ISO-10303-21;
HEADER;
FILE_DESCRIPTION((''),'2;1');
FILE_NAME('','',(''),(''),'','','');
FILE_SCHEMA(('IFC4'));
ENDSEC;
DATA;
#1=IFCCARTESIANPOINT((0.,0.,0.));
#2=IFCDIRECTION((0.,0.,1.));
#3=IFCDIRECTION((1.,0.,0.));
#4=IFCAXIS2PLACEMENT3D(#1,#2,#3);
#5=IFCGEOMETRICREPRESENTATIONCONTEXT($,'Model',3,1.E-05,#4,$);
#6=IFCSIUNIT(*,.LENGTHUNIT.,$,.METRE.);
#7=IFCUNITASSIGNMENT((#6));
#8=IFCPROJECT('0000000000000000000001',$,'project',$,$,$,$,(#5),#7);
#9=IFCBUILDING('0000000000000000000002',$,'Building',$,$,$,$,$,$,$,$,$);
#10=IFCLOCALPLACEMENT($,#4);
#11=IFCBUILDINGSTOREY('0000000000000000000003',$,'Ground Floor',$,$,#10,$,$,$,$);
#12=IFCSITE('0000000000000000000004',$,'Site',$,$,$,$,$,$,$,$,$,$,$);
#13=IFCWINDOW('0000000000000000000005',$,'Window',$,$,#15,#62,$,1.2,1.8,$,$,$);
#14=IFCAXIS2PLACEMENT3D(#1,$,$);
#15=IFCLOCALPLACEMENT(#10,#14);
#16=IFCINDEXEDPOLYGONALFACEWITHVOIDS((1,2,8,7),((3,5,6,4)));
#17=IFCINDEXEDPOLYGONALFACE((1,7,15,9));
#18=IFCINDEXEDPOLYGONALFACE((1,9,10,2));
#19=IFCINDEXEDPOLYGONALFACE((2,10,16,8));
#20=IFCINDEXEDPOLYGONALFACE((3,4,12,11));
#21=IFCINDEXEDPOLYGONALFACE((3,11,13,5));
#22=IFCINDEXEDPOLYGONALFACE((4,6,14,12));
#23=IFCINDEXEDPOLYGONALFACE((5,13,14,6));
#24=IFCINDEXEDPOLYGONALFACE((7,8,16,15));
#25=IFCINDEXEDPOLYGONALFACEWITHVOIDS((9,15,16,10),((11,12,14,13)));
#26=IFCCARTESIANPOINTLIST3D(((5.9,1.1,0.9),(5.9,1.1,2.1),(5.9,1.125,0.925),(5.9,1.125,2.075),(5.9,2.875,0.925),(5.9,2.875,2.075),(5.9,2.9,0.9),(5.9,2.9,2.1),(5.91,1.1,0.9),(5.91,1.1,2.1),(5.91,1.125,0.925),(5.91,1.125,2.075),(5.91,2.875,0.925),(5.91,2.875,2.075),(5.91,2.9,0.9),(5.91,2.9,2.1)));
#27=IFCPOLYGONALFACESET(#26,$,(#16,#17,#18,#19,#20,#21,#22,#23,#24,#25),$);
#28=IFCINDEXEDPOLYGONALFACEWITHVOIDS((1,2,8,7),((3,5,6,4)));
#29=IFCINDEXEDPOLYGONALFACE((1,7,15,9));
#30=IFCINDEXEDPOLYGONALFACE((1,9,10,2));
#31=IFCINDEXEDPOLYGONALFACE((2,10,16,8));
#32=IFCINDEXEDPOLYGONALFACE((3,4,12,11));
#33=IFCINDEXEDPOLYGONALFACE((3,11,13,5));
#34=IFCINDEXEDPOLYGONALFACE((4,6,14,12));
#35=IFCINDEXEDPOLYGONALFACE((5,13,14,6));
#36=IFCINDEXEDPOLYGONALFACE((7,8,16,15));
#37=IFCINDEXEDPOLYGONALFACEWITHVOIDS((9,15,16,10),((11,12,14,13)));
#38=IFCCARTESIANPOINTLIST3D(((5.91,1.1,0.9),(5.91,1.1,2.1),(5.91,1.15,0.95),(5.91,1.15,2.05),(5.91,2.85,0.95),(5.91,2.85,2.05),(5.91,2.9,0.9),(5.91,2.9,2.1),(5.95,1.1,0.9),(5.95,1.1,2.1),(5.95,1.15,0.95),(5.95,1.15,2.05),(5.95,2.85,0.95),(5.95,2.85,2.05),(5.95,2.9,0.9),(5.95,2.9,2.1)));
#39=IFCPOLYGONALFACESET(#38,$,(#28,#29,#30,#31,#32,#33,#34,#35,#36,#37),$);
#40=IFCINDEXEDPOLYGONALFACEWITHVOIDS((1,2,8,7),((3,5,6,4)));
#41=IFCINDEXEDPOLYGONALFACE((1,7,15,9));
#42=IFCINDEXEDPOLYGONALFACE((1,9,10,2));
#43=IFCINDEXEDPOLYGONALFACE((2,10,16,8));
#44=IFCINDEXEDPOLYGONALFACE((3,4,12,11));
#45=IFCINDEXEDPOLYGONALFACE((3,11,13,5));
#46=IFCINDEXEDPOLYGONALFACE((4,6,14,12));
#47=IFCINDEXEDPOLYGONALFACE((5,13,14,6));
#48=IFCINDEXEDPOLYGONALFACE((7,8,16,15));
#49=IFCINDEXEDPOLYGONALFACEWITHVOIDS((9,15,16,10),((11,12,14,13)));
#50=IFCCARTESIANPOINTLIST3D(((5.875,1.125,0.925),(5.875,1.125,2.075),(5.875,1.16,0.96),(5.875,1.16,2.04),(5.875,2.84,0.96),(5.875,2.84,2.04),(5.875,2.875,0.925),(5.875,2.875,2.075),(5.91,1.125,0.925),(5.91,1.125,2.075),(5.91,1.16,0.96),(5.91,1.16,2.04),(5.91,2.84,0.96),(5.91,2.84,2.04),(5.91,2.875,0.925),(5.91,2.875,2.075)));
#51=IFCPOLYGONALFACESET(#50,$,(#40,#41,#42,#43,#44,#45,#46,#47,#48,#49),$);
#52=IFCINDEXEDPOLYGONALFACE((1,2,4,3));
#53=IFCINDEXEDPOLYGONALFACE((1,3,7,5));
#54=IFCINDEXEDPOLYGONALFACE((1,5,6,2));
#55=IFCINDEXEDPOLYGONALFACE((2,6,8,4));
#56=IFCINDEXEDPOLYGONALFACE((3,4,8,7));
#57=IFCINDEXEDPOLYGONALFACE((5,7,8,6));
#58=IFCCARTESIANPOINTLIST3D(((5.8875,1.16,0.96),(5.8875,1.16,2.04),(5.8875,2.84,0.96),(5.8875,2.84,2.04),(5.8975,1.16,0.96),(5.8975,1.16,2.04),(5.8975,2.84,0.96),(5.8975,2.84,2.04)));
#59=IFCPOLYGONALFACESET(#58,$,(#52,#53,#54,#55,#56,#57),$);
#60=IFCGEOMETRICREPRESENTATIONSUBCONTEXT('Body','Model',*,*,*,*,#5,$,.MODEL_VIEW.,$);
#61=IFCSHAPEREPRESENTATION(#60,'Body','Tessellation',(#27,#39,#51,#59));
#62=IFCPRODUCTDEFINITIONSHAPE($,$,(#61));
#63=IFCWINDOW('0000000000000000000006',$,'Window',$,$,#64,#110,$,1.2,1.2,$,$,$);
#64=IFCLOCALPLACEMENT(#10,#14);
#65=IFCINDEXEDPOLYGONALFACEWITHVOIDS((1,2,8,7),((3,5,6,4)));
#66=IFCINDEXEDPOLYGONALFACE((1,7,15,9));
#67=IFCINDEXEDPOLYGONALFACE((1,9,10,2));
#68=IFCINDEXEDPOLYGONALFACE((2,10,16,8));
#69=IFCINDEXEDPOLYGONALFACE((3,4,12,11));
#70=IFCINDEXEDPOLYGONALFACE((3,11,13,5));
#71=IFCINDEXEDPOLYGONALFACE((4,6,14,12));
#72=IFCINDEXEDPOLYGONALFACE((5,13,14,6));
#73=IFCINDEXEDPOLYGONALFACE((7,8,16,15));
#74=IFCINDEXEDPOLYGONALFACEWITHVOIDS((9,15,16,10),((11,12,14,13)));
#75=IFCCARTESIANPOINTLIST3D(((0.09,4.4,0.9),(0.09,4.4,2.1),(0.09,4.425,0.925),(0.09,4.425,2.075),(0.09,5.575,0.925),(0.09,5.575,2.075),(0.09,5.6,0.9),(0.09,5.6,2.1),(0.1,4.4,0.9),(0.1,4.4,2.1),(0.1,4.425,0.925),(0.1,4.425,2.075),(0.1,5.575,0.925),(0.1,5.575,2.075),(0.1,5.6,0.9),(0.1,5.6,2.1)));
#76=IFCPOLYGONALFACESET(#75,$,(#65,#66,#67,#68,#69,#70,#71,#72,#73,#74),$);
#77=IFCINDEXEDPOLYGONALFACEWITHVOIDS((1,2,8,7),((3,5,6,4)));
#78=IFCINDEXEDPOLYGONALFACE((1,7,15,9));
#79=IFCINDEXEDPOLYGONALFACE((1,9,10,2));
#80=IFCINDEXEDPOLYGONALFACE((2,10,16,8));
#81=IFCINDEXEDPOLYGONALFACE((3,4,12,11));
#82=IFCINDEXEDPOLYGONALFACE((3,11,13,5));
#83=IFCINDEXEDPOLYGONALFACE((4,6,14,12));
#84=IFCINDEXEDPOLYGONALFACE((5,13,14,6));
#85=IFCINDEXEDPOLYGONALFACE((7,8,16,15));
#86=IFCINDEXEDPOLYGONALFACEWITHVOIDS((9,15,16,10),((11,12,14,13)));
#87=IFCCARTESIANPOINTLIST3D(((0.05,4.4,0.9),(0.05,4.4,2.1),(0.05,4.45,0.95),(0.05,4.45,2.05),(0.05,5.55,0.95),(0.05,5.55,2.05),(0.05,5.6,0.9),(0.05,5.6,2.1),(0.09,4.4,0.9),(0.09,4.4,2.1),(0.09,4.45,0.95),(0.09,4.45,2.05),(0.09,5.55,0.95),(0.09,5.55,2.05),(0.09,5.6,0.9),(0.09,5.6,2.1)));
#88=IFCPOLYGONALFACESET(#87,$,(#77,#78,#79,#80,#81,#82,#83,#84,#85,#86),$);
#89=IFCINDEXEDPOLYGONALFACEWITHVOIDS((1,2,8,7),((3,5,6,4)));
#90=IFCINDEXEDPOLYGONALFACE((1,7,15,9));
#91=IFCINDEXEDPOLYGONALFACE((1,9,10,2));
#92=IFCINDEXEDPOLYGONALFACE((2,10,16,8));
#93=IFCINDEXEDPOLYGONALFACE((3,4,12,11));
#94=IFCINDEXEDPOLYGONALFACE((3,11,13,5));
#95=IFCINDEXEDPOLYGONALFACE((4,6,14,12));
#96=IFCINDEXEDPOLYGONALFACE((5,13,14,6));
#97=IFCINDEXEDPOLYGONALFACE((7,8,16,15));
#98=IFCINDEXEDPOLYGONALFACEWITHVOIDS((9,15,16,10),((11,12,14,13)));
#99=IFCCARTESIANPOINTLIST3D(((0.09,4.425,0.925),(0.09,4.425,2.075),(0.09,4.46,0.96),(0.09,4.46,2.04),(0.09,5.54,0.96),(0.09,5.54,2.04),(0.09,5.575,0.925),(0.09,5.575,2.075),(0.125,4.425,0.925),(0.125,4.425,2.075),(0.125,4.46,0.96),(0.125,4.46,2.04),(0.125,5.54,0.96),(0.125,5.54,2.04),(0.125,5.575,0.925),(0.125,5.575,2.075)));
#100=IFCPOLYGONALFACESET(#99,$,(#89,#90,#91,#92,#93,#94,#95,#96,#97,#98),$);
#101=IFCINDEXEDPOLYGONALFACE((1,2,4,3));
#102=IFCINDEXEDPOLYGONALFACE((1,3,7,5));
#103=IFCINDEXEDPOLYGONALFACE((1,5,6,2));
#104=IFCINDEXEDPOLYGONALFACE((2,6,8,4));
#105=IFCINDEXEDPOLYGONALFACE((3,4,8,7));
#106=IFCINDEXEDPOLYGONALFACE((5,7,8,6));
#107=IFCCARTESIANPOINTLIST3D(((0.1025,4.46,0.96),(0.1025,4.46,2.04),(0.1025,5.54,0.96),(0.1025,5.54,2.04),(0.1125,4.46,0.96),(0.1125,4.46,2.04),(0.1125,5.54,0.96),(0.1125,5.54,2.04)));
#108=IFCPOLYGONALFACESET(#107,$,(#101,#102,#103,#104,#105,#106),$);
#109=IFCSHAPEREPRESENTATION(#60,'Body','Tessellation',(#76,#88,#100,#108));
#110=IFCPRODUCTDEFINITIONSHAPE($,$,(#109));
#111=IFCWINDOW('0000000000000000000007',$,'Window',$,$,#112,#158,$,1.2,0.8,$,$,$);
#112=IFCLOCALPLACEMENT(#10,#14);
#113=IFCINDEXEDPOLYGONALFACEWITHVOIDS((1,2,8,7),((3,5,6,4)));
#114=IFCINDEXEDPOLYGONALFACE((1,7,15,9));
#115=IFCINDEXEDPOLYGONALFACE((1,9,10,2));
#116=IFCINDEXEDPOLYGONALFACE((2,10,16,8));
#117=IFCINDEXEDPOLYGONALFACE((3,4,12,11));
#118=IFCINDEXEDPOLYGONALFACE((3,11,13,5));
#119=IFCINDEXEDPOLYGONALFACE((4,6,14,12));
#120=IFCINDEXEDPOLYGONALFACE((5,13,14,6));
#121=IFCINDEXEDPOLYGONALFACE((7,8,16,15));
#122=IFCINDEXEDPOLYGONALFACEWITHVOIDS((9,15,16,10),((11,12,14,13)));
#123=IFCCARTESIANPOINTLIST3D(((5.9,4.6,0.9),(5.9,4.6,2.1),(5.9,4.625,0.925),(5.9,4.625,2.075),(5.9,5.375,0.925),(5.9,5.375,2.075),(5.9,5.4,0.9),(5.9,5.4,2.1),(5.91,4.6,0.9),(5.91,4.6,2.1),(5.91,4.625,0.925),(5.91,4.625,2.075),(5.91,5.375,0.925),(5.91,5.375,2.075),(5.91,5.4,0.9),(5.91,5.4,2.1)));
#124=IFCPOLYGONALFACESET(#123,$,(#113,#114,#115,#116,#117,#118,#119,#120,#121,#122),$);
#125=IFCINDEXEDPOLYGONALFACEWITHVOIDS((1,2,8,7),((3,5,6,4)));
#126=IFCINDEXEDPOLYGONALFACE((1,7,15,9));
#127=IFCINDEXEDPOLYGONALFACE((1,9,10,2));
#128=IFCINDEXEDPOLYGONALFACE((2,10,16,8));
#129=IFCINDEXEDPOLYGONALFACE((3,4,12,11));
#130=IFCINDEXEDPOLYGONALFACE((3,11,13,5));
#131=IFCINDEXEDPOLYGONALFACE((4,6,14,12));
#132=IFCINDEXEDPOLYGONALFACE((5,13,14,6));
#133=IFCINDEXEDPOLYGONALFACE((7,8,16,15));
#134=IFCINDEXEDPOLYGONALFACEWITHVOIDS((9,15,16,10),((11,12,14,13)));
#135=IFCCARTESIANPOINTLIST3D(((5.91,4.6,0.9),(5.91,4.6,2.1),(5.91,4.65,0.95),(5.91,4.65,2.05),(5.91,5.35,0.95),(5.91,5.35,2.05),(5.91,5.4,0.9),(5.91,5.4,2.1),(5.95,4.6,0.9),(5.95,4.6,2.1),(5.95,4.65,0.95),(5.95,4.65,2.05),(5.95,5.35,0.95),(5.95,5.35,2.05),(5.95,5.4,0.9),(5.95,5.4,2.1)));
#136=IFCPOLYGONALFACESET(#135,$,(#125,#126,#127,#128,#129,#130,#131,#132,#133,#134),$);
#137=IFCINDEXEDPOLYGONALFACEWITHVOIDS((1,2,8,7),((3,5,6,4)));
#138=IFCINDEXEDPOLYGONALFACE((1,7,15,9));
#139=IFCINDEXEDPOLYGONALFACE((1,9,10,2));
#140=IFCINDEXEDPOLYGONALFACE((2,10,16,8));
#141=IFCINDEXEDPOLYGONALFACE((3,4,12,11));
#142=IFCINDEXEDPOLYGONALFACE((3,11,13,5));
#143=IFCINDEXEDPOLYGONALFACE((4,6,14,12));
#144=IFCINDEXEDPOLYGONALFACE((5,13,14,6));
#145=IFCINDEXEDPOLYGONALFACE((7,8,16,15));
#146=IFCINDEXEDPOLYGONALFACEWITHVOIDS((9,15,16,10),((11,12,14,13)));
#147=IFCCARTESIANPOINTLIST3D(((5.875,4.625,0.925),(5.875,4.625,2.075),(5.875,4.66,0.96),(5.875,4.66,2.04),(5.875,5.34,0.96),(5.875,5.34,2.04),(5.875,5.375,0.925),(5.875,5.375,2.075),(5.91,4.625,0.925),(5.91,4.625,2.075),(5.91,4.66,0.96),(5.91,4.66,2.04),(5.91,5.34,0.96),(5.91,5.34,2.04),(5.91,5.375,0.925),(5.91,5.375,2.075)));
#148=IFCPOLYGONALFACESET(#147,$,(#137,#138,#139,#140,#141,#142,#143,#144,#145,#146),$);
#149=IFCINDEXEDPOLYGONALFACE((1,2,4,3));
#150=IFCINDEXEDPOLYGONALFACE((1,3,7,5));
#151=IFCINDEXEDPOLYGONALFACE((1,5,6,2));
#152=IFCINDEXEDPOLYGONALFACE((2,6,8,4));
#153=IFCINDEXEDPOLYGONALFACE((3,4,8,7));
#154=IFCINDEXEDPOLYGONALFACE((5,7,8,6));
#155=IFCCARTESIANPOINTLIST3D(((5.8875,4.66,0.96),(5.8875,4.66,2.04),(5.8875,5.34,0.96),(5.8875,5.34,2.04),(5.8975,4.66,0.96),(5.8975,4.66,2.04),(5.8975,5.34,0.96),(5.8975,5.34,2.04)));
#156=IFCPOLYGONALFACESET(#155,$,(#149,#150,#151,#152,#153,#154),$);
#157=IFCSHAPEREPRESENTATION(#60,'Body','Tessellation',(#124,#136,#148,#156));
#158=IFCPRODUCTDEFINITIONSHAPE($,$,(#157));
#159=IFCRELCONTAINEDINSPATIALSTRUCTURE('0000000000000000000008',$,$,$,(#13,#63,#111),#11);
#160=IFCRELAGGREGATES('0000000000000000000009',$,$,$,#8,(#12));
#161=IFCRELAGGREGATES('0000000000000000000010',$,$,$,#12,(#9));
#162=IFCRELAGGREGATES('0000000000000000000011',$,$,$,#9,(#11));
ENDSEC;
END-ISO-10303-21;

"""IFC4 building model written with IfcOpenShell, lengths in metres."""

from ifc_helpers import new_model, si_unit, frame, origin_with_axes, place, context, subcontext, project, spatial, line, indexed_curve, outline, extrude, element, save


model = new_model("IFC4")

# Units and contexts
model_context = context("Model", 3, precision=1e-05, world=origin_with_axes())
body_context = subcontext(model_context, "Body", "Model", "MODEL_VIEW")
ifc_project = project(units=[si_unit("LENGTHUNIT", "METRE")], contexts=[model_context])

# Site, building, storey
site = spatial("IfcSite", under=ifc_project, Name="Site")
building = spatial("IfcBuilding", under=site, Name="Building")
storey_placement = place(None, origin_with_axes())
storey = spatial("IfcBuildingStorey", under=building, at=storey_placement, Name="Ground Floor")

# Windows
for number, where, z_axis, x_axis, name in (
    (1, (6.0, 1.1, 0.9), (0.0, 0.0, 1.0), (0.0, 1.0, 0.0), "Window"),
):
    element("IfcWindow", number, at=place(storey_placement, frame(where, z_axis=z_axis, x_axis=x_axis)), inside=storey, Name=name, OverallHeight=1.2, OverallWidth=1.8, context=body_context, shape_type="SweptSolid", body=[
        extrude(outline(indexed_curve([(0.0, 0.0), (1.8, 0.0), (1.8, 1.2), (0.0, 1.2)], segments=[line(1, 2, 3, 4, 1)]), holes=[indexed_curve([(0.025, 0.025), (1.775, 0.025), (1.775, 1.175), (0.025, 1.175)], segments=[line(1, 2, 3, 4, 1)])]), frame((0.0, 0.09, 0.0), z_axis=(0.0, -1.0, 0.0), x_axis=(1.0, 0.0, 0.0)), (0.0, 0.0, -1.0), 0.01),
        extrude(outline(indexed_curve([(0.0, 0.0), (1.8, 0.0), (1.8, 1.2), (0.0, 1.2)], segments=[line(1, 2, 3, 4, 1)]), holes=[indexed_curve([(0.05, 0.05), (1.75, 0.05), (1.75, 1.15), (0.05, 1.15)], segments=[line(1, 2, 3, 4, 1)])]), frame((0.0, 0.05, 0.0), z_axis=(0.0, -1.0, 0.0), x_axis=(1.0, 0.0, 0.0)), (0.0, 0.0, -1.0), 0.04),
        extrude(outline(indexed_curve([(0.0, 0.0), (1.75, 0.0), (1.75, 1.15), (0.0, 1.15)], segments=[line(1, 2, 3, 4, 1)]), holes=[indexed_curve([(0.035, 0.035), (1.715, 0.035), (1.715, 1.115), (0.035, 1.115)], segments=[line(1, 2, 3, 4, 1)])]), frame((0.025, 0.09, 0.025), z_axis=(0.0, -1.0, 0.0), x_axis=(1.0, 0.0, 0.0)), (0.0, 0.0, -1.0), 0.035),
        extrude(outline(indexed_curve([(0.035, 0.035), (1.715, 0.035), (1.715, 1.115), (0.035, 1.115)], segments=[line(1, 2, 3, 4, 1)])), frame((0.025, 0.1025, 0.025), z_axis=(0.0, -1.0, 0.0), x_axis=(1.0, 0.0, 0.0)), (0.0, 0.0, -1.0), 0.01),
    ])
window_1_placement = place(storey_placement, frame((0.0, 5.6, 0.9), z_axis=(0.0, 0.0, 1.0), x_axis=(0.0, -1.0, 0.0)))
element("IfcWindow", 2, at=window_1_placement, inside=storey, Name="Window", OverallHeight=1.2, OverallWidth=1.2, context=body_context, shape_type="SweptSolid", body=[
    extrude(outline(indexed_curve([(0.0, 0.0), (1.2, 0.0), (1.2, 1.2), (0.0, 1.2)], segments=[line(1, 2, 3, 4, 1)]), holes=[indexed_curve([(0.025, 0.025), (1.175, 0.025), (1.175, 1.175), (0.025, 1.175)], segments=[line(1, 2, 3, 4, 1)])]), frame((0.0, 0.09, 0.0), z_axis=(0.0, -1.0, 0.0), x_axis=(1.0, 0.0, 0.0)), (0.0, 0.0, -1.0), 0.01),
    extrude(outline(indexed_curve([(0.0, 0.0), (1.2, 0.0), (1.2, 1.2), (0.0, 1.2)], segments=[line(1, 2, 3, 4, 1)]), holes=[indexed_curve([(0.05, 0.05), (1.15, 0.05), (1.15, 1.15), (0.05, 1.15)], segments=[line(1, 2, 3, 4, 1)])]), frame((0.0, 0.05, 0.0), z_axis=(0.0, -1.0, 0.0), x_axis=(1.0, 0.0, 0.0)), (0.0, 0.0, -1.0), 0.04),
    extrude(outline(indexed_curve([(0.0, 0.0), (1.15, 0.0), (1.15, 1.15), (0.0, 1.15)], segments=[line(1, 2, 3, 4, 1)]), holes=[indexed_curve([(0.035, 0.035), (1.115, 0.035), (1.115, 1.115), (0.035, 1.115)], segments=[line(1, 2, 3, 4, 1)])]), frame((0.025, 0.09, 0.025), z_axis=(0.0, -1.0, 0.0), x_axis=(1.0, 0.0, 0.0)), (0.0, 0.0, -1.0), 0.035),
    extrude(outline(indexed_curve([(0.035, 0.035), (1.115, 0.035), (1.115, 1.115), (0.035, 1.115)], segments=[line(1, 2, 3, 4, 1)])), frame((0.025, 0.1025, 0.025), z_axis=(0.0, -1.0, 0.0), x_axis=(1.0, 0.0, 0.0)), (0.0, 0.0, -1.0), 0.01),
])
window_2_placement = place(storey_placement, frame((6.0, 4.6, 0.9), z_axis=(0.0, 0.0, 1.0), x_axis=(0.0, 1.0, 0.0)))
element("IfcWindow", 3, at=window_2_placement, inside=storey, Name="Window", OverallHeight=1.2, OverallWidth=0.8, context=body_context, shape_type="SweptSolid", body=[
    extrude(outline(indexed_curve([(0.0, 0.0), (0.8, 0.0), (0.8, 1.2), (0.0, 1.2)], segments=[line(1, 2, 3, 4, 1)]), holes=[indexed_curve([(0.025, 0.025), (0.775, 0.025), (0.775, 1.175), (0.025, 1.175)], segments=[line(1, 2, 3, 4, 1)])]), frame((0.0, 0.09, 0.0), z_axis=(0.0, -1.0, 0.0), x_axis=(1.0, 0.0, 0.0)), (0.0, 0.0, -1.0), 0.01),
    extrude(outline(indexed_curve([(0.0, 0.0), (0.8, 0.0), (0.8, 1.2), (0.0, 1.2)], segments=[line(1, 2, 3, 4, 1)]), holes=[indexed_curve([(0.05, 0.05), (0.75, 0.05), (0.75, 1.15), (0.05, 1.15)], segments=[line(1, 2, 3, 4, 1)])]), frame((0.0, 0.05, 0.0), z_axis=(0.0, -1.0, 0.0), x_axis=(1.0, 0.0, 0.0)), (0.0, 0.0, -1.0), 0.04),
    extrude(outline(indexed_curve([(0.0, 0.0), (0.75, 0.0), (0.75, 1.15), (0.0, 1.15)], segments=[line(1, 2, 3, 4, 1)]), holes=[indexed_curve([(0.035, 0.035), (0.715, 0.035), (0.715, 1.115), (0.035, 1.115)], segments=[line(1, 2, 3, 4, 1)])]), frame((0.025, 0.09, 0.025), z_axis=(0.0, -1.0, 0.0), x_axis=(1.0, 0.0, 0.0)), (0.0, 0.0, -1.0), 0.035),
    extrude(outline(indexed_curve([(0.035, 0.035), (0.715, 0.035), (0.715, 1.115), (0.035, 1.115)], segments=[line(1, 2, 3, 4, 1)])), frame((0.025, 0.1025, 0.025), z_axis=(0.0, -1.0, 0.0), x_axis=(1.0, 0.0, 0.0)), (0.0, 0.0, -1.0), 0.01),
])

save(model, "model.ifc")
